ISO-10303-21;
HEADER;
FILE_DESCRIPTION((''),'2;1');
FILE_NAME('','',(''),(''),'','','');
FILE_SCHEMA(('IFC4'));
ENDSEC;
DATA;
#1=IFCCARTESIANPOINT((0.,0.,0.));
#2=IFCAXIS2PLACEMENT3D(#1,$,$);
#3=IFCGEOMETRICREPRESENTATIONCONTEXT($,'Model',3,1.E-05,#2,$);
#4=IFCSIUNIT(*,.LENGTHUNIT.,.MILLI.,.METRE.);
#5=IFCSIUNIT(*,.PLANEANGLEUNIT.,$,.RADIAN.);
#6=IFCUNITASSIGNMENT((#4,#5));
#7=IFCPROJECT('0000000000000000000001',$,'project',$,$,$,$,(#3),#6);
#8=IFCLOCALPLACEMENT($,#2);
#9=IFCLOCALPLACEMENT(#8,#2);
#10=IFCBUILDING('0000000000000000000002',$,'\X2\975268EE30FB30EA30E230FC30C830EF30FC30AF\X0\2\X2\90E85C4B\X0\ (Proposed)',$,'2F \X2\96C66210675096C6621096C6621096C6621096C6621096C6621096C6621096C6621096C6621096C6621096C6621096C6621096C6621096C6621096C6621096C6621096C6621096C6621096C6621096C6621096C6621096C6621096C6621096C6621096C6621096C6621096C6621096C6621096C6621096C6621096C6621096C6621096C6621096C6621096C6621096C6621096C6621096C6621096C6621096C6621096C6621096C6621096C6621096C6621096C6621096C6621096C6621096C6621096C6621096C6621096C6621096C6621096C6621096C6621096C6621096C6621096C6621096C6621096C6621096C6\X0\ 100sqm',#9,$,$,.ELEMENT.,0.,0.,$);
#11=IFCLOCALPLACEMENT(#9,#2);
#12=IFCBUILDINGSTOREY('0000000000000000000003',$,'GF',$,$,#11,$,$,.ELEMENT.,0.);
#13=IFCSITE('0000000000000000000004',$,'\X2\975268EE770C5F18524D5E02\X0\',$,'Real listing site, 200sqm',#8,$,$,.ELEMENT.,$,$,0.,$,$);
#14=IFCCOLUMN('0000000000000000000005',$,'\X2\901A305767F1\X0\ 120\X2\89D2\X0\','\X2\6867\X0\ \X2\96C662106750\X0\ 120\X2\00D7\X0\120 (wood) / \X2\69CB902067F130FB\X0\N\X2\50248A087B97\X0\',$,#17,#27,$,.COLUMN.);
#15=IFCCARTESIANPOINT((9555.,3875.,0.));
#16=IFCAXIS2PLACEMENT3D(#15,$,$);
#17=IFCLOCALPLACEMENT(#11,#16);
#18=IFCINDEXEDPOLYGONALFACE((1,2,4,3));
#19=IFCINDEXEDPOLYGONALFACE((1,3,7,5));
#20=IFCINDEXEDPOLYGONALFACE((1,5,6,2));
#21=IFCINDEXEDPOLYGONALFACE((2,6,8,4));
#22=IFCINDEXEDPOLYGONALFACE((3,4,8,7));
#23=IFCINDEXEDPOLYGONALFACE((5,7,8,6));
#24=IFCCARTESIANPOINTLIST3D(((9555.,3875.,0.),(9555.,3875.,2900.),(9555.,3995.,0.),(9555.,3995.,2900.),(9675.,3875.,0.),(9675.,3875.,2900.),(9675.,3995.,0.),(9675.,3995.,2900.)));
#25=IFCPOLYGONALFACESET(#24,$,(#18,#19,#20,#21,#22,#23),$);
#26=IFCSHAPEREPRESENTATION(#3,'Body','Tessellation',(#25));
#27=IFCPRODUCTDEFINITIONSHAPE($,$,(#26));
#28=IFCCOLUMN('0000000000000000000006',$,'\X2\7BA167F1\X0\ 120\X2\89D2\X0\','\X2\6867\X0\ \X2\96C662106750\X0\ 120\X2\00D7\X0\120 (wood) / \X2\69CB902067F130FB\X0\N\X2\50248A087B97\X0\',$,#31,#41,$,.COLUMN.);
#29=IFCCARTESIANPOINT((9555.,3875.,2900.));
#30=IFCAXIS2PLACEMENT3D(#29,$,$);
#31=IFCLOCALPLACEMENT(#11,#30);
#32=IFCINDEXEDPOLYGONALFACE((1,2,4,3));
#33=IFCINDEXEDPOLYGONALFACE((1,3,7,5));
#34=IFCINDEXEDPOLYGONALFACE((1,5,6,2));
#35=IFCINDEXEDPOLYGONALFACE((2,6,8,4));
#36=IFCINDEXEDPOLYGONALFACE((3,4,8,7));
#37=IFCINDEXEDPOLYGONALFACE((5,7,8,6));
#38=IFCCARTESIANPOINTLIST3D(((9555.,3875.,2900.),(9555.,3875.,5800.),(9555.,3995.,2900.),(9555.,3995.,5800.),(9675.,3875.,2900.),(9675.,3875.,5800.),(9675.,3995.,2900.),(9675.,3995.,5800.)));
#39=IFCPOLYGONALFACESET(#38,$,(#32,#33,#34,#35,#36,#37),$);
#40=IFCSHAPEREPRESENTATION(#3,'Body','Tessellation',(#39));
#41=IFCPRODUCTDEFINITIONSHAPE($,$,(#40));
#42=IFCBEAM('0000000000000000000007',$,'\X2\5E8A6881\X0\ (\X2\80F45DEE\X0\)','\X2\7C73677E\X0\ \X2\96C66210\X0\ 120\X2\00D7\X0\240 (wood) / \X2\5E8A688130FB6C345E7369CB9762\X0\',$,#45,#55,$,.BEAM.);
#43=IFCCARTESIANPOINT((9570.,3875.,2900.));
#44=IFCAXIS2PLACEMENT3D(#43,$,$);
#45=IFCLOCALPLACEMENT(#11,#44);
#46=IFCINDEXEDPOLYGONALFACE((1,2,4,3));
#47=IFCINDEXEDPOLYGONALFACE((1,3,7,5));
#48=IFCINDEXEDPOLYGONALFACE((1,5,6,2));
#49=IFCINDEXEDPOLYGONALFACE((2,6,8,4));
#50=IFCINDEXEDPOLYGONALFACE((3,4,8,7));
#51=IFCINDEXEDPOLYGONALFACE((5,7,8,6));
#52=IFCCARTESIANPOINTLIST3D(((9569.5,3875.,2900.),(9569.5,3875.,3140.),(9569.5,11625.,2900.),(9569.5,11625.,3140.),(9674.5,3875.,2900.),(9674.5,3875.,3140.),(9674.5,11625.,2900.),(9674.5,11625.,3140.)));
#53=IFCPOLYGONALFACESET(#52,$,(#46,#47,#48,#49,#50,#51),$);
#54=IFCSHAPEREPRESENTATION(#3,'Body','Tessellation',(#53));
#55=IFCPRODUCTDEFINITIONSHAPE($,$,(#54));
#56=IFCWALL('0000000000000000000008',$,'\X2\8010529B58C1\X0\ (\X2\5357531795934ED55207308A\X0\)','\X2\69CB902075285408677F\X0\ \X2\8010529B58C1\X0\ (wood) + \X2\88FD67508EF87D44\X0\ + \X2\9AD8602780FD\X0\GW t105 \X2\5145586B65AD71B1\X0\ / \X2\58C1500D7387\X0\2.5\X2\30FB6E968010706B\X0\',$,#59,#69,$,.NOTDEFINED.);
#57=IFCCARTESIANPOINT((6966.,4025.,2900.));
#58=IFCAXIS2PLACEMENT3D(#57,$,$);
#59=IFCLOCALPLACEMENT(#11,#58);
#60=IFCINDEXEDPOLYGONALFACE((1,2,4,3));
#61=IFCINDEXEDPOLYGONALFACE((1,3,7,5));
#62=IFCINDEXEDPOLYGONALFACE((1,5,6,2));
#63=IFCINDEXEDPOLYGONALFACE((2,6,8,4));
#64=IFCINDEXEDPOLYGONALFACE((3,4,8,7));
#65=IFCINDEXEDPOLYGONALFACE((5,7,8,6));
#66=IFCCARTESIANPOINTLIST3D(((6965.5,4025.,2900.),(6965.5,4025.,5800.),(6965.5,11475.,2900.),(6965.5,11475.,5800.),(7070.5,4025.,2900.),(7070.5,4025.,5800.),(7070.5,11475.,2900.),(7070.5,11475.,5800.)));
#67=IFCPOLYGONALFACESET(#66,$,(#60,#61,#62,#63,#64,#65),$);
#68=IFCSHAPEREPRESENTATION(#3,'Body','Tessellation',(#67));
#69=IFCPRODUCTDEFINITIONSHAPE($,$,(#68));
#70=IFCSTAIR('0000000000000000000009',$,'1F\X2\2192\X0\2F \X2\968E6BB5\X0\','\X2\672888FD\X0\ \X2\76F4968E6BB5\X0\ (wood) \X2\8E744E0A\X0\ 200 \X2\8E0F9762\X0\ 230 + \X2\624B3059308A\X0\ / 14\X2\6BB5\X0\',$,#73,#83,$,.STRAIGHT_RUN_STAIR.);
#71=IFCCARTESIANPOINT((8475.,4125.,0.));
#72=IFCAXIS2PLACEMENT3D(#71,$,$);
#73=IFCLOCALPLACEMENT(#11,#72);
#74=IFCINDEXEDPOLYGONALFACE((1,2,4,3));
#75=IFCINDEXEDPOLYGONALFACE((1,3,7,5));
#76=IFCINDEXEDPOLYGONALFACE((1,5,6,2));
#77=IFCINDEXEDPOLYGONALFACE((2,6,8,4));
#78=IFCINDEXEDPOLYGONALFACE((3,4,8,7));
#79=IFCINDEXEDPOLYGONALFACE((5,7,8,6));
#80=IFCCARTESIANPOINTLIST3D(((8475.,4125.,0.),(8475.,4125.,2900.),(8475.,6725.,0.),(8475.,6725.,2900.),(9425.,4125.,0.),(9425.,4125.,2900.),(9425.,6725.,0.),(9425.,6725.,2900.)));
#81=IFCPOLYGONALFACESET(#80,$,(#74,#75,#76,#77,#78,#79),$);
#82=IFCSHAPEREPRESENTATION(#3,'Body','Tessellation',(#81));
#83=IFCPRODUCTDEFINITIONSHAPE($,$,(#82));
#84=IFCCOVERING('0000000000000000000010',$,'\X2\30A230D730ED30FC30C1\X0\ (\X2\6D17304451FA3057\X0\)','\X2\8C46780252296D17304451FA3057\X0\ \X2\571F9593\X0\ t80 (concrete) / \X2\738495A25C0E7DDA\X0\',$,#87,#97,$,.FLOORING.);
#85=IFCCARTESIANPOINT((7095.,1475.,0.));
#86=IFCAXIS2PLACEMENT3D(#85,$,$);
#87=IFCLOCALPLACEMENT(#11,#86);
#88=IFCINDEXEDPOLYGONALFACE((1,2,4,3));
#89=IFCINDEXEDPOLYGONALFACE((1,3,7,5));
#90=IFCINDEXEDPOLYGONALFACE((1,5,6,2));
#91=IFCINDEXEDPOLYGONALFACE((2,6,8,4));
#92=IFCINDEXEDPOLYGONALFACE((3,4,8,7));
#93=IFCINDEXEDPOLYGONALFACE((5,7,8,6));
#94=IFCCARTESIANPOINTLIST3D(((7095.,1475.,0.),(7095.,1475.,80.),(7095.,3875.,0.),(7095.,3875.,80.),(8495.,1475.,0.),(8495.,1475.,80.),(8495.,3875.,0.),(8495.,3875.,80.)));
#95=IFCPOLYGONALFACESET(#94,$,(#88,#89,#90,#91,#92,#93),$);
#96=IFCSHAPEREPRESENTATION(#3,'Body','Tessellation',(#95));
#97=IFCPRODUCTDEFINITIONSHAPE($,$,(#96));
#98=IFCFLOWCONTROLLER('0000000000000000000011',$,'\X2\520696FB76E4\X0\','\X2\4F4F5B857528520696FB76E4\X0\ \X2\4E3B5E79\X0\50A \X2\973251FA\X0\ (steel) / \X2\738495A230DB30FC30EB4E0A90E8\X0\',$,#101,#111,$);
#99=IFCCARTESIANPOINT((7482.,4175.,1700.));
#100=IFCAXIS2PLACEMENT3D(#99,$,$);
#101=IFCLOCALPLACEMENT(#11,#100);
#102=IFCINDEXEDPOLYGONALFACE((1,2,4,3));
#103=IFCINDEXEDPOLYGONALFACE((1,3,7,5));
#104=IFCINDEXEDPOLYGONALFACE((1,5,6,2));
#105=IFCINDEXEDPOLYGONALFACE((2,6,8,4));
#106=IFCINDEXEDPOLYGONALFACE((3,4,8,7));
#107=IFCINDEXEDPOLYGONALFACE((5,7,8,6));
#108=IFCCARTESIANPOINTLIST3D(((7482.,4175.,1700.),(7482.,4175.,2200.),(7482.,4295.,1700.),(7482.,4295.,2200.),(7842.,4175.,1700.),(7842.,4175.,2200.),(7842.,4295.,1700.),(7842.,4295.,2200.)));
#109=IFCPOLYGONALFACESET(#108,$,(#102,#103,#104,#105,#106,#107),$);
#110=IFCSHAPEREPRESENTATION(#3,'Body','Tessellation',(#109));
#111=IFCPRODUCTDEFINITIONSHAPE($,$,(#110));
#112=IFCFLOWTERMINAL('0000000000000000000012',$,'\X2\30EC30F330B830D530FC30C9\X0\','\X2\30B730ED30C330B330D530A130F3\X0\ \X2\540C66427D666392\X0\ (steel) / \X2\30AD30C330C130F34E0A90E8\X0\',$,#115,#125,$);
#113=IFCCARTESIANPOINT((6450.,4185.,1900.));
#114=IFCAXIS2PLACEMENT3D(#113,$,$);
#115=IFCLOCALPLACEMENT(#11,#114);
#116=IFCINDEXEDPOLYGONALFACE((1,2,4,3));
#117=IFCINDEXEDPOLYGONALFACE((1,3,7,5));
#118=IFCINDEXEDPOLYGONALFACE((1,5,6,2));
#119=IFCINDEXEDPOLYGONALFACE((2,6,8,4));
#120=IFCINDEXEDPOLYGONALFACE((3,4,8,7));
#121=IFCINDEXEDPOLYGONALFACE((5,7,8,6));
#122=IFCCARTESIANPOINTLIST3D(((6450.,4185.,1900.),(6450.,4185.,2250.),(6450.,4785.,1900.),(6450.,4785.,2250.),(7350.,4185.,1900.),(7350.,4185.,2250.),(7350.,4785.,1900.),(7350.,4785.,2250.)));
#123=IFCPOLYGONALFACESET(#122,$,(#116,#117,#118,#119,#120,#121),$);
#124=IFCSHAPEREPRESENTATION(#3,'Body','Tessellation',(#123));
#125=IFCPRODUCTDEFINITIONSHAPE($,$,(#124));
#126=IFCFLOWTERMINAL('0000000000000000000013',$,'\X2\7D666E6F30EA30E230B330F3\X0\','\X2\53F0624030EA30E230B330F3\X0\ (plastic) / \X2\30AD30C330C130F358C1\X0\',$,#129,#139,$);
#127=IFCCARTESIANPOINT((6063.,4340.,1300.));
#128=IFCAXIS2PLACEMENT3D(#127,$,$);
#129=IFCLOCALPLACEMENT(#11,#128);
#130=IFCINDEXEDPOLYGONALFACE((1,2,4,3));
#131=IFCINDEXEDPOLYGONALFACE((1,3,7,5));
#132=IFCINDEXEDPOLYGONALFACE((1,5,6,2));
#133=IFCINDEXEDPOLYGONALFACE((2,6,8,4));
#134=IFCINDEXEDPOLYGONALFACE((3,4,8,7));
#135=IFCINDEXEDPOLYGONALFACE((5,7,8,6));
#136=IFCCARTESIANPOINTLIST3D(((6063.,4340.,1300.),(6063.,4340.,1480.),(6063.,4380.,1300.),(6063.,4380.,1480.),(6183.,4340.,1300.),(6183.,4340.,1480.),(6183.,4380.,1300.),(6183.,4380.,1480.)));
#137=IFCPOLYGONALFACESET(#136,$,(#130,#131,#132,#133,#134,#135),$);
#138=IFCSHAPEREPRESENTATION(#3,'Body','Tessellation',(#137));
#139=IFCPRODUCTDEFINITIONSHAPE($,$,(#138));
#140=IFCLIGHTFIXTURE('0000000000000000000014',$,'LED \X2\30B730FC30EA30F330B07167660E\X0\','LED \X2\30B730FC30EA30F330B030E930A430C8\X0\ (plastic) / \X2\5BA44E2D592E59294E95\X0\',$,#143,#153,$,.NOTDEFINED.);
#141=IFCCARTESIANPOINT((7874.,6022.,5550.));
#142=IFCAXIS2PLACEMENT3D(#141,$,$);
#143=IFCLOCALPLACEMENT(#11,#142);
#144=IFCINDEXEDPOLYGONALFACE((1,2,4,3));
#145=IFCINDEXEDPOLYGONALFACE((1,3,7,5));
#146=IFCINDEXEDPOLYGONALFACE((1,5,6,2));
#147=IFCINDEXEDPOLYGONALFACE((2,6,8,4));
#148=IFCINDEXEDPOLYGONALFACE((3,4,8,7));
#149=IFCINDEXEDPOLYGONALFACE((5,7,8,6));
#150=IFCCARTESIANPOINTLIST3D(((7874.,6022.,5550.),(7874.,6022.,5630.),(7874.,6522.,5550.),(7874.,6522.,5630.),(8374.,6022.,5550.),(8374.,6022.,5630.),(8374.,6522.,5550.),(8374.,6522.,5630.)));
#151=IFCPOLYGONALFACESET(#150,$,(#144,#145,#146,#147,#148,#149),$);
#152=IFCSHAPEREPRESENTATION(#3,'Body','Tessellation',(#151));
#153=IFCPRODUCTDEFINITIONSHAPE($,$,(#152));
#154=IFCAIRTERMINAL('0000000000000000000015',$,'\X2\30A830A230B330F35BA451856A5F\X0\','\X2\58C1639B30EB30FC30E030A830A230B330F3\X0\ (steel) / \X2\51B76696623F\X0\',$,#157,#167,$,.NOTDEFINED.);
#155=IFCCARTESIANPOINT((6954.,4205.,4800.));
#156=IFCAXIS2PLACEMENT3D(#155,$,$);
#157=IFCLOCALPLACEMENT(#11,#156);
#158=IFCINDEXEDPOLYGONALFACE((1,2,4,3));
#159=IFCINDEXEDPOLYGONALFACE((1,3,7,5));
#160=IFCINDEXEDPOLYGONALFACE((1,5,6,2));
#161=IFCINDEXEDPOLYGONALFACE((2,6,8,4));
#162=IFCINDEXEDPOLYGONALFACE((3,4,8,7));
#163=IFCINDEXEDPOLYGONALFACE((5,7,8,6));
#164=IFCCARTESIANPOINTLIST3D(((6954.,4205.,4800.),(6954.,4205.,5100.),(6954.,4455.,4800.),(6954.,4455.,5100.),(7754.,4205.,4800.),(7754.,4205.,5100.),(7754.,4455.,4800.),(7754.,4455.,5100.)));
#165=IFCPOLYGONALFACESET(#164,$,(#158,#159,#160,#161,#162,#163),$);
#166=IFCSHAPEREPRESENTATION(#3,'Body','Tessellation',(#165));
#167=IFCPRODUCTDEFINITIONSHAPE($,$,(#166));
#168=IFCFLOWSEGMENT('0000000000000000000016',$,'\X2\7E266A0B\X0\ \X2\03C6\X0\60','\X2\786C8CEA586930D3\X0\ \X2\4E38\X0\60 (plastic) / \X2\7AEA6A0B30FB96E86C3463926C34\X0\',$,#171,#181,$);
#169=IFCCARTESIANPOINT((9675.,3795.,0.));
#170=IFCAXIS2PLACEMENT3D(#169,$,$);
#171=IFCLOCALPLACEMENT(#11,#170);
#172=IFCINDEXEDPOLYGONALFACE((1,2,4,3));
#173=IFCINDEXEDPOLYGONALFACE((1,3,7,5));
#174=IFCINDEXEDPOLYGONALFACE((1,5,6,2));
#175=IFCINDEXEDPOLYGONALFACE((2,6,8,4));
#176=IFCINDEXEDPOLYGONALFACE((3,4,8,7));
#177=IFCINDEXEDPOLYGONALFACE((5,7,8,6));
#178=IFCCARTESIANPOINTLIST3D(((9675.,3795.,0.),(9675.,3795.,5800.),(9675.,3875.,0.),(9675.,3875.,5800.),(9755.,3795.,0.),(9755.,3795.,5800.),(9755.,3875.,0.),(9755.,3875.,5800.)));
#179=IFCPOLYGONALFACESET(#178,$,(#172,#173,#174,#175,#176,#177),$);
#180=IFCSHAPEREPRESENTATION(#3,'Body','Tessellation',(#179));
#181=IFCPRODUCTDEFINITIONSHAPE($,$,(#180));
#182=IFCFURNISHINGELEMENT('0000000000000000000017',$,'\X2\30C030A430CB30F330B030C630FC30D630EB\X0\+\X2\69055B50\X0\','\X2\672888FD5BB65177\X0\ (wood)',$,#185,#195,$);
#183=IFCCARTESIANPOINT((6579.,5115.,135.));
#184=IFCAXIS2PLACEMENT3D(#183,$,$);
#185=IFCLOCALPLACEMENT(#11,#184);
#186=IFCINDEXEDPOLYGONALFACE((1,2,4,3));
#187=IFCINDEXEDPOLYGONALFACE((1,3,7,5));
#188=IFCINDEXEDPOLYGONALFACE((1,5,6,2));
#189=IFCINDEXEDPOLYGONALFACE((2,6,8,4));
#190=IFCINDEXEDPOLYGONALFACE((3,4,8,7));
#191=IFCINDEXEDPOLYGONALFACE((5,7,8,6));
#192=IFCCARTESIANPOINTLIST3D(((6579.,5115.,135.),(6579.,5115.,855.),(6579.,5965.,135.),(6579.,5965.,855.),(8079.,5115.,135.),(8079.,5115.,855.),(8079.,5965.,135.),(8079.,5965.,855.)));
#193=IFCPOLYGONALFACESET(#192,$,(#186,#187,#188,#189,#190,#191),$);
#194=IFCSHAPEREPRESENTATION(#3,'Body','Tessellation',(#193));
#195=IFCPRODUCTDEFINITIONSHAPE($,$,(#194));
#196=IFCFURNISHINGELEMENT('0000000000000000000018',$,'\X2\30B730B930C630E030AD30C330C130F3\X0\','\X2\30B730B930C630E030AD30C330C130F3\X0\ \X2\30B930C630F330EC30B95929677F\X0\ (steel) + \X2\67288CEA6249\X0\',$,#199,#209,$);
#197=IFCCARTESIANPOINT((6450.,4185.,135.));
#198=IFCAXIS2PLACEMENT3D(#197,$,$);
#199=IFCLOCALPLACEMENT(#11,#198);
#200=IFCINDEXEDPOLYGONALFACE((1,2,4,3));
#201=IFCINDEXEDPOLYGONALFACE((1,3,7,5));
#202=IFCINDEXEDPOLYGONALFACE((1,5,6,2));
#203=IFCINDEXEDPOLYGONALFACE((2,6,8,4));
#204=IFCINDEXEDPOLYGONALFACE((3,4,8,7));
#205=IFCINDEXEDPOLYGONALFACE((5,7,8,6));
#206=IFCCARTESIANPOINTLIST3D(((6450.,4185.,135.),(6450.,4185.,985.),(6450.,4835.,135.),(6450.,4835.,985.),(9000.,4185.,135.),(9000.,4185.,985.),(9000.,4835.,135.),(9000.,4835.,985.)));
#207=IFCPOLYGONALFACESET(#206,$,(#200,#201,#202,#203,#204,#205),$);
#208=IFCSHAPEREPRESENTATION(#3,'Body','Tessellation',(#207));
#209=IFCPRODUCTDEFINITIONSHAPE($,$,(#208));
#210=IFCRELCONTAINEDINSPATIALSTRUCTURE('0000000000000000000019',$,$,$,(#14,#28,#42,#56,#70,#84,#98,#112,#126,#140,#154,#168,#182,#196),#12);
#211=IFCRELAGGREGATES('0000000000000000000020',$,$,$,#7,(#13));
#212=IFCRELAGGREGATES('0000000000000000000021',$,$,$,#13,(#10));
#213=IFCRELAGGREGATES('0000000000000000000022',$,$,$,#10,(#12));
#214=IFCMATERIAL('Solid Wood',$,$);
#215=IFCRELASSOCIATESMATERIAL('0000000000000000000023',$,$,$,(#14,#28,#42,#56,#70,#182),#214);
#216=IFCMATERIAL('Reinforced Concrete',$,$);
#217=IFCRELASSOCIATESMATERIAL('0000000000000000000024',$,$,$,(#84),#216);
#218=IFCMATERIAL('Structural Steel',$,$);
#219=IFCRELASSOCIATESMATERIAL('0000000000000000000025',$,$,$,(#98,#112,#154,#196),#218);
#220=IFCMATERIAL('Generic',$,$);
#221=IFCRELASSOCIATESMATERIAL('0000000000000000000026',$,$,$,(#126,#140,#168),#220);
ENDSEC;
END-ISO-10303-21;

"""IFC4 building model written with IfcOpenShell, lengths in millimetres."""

from ifc_helpers import new_model, si_unit, frame, frame_2d, origin, place, context, project, spatial, rectangle, extrude, material, element, save


model = new_model("IFC4")

# Units and contexts
model_context = context("Model", 3, precision=1e-05, world=origin())
ifc_project = project(units=[si_unit("LENGTHUNIT", "METRE", prefix="MILLI"), si_unit("PLANEANGLEUNIT", "RADIAN")], contexts=[model_context])

# Site, building, storey
site_placement = place(None, origin())
site = spatial("IfcSite", under=ifc_project, at=site_placement, Name="青森県弘前市", ObjectType="Real listing site, 200sqm", CompositionType="ELEMENT", RefElevation=0.0)
building_placement = place(site_placement, origin())
building = spatial("IfcBuilding", under=site, at=building_placement, Name="青森・リモートワーク2部屋 (Proposed)", ObjectType="2F 集成材集成集成集成集成集成集成集成集成集成集成集成集成集成集成集成集成集成集成集成集成集成集成集成集成集成集成集成集成集成集成集成集成集成集成集成集成集成集成集成集成集成集成集成集成集成集成集成集成集成集成集成集成集成集成集成集成集成集成集 100sqm", CompositionType="ELEMENT", ElevationOfRefHeight=0.0, ElevationOfTerrain=0.0)
storey_placement = place(building_placement, origin())
storey = spatial("IfcBuildingStorey", under=building, at=storey_placement, Name="GF", CompositionType="ELEMENT", Elevation=0.0)

# Columns
ifc_material_1 = material(Name="Solid Wood")
column_1_placement = place(storey_placement, frame((9555.0, 3875.0, 0.0)))
element("IfcColumn", 1, at=column_1_placement, inside=storey, material=ifc_material_1, Name="通し柱 120角", Description="桧 集成材 120×120 (wood) / 構造柱・N値計算", PredefinedType="COLUMN", context=model_context, shape_type="SweptSolid", body=[
    extrude(rectangle(XDim=120.0, YDim=120.0, at=frame_2d((60.0, 60.0))), frame((9555.0, 3875.0, 0.0)), (0.0, 0.0, 1.0), 2900.0),
])
column_2_placement = place(storey_placement, frame((9555.0, 3875.0, 2900.0)))
element("IfcColumn", 2, at=column_2_placement, inside=storey, material=ifc_material_1, Name="管柱 120角", Description="桧 集成材 120×120 (wood) / 構造柱・N値計算", PredefinedType="COLUMN", context=model_context, shape_type="SweptSolid", body=[
    extrude(rectangle(XDim=120.0, YDim=120.0, at=frame_2d((60.0, 60.0))), frame((9555.0, 3875.0, 2900.0)), (0.0, 0.0, 1.0), 2900.0),
])

# Beam
beam_1_placement = place(storey_placement, frame((9570.0, 3875.0, 2900.0)))
element("IfcBeam", 3, at=beam_1_placement, inside=storey, material=ifc_material_1, Name="床梁 (胴差)", Description="米松 集成 120×240 (wood) / 床梁・水平構面", PredefinedType="BEAM", context=model_context, shape_type="SweptSolid", body=[
    extrude(rectangle(XDim=105.0, YDim=7750.0, at=frame_2d((52.0, 3875.0))), frame((9570.0, 3875.0, 2900.0)), (0.0, 0.0, 1.0), 240.0),
])

# Wall
wall_1_placement = place(storey_placement, frame((6966.0, 4025.0, 2900.0)))
element("IfcWall", 4, at=wall_1_placement, inside=storey, material=ifc_material_1, Name="耐力壁 (南北間仕切り)", Description="構造用合板 耐力壁 (wood) + 製材軸組 + 高性能GW t105 充填断熱 / 壁倍率2.5・準耐火", PredefinedType="NOTDEFINED", context=model_context, shape_type="SweptSolid", body=[
    extrude(rectangle(XDim=105.0, YDim=7450.0, at=frame_2d((52.0, 3725.0))), frame((6966.0, 4025.0, 2900.0)), (0.0, 0.0, 1.0), 2900.0),
])

# Stair
stair_placement = place(storey_placement, frame((8475.0, 4125.0, 0.0)))
element("IfcStair", 5, at=stair_placement, inside=storey, material=ifc_material_1, Name="1F→2F 階段", Description="木製 直階段 (wood) 蹴上 200 踏面 230 + 手すり / 14段", PredefinedType="STRAIGHT_RUN_STAIR", context=model_context, shape_type="SweptSolid", body=[
    extrude(rectangle(XDim=950.0, YDim=2600.0, at=frame_2d((475.0, 1300.0))), frame((8475.0, 4125.0, 0.0)), (0.0, 0.0, 1.0), 2900.0),
])

# Covering
ifc_material_2 = material(Name="Reinforced Concrete")
covering_placement = place(storey_placement, frame((7095.0, 1475.0, 0.0)))
element("IfcCovering", 6, at=covering_placement, inside=storey, material=ifc_material_2, Name="アプローチ (洗い出し)", Description="豆砂利洗い出し 土間 t80 (concrete) / 玄関導線", PredefinedType="FLOORING", context=model_context, shape_type="SweptSolid", body=[
    extrude(rectangle(XDim=1400.0, YDim=2400.0, at=frame_2d((700.0, 1200.0))), frame((7095.0, 1475.0, 0.0)), (0.0, 0.0, 1.0), 80.0),
])

# Flow controller
ifc_material_3 = material(Name="Structural Steel")
flow_controller_placement = place(storey_placement, frame((7482.0, 4175.0, 1700.0)))
element("IfcFlowController", 7, at=flow_controller_placement, inside=storey, material=ifc_material_3, Name="分電盤", Description="住宅用分電盤 主幹50A 露出 (steel) / 玄関ホール上部", context=model_context, shape_type="SweptSolid", body=[
    extrude(rectangle(XDim=360.0, YDim=120.0, at=frame_2d((180.0, 60.0))), frame((7482.0, 4175.0, 1700.0)), (0.0, 0.0, 1.0), 500.0),
])

# Flow terminals
flow_terminal_1_placement = place(storey_placement, frame((6450.0, 4185.0, 1900.0)))
element("IfcFlowTerminal", 8, at=flow_terminal_1_placement, inside=storey, material=ifc_material_3, Name="レンジフード", Description="シロッコファン 同時給排 (steel) / キッチン上部", context=model_context, shape_type="SweptSolid", body=[
    extrude(rectangle(XDim=900.0, YDim=600.0, at=frame_2d((450.0, 300.0))), frame((6450.0, 4185.0, 1900.0)), (0.0, 0.0, 1.0), 350.0),
])
ifc_material_4 = material(Name="Generic")
flow_terminal_2_placement = place(storey_placement, frame((6063.0, 4340.0, 1300.0)))
element("IfcFlowTerminal", 9, at=flow_terminal_2_placement, inside=storey, material=ifc_material_4, Name="給湯リモコン", Description="台所リモコン (plastic) / キッチン壁", context=model_context, shape_type="SweptSolid", body=[
    extrude(rectangle(XDim=120.0, YDim=40.0, at=frame_2d((60.0, 20.0))), frame((6063.0, 4340.0, 1300.0)), (0.0, 0.0, 1.0), 180.0),
])

# Light fixture
light_fixture_placement = place(storey_placement, frame((7874.0, 6022.0, 5550.0)))
element("IfcLightFixture", 10, at=light_fixture_placement, inside=storey, material=ifc_material_4, Name="LED シーリング照明", Description="LED シーリングライト (plastic) / 室中央天井", PredefinedType="NOTDEFINED", context=model_context, shape_type="SweptSolid", body=[
    extrude(rectangle(XDim=500.0, YDim=500.0, at=frame_2d((250.0, 250.0))), frame((7874.0, 6022.0, 5550.0)), (0.0, 0.0, 1.0), 80.0),
])

# Air terminal
air_terminal_placement = place(storey_placement, frame((6954.0, 4205.0, 4800.0)))
element("IfcAirTerminal", 11, at=air_terminal_placement, inside=storey, material=ifc_material_3, Name="エアコン室内機", Description="壁掛ルームエアコン (steel) / 冷暖房", PredefinedType="NOTDEFINED", context=model_context, shape_type="SweptSolid", body=[
    extrude(rectangle(XDim=800.0, YDim=250.0, at=frame_2d((400.0, 125.0))), frame((6954.0, 4205.0, 4800.0)), (0.0, 0.0, 1.0), 300.0),
])

# Flow segment
flow_segment_placement = place(storey_placement, frame((9675.0, 3795.0, 0.0)))
element("IfcFlowSegment", 12, at=flow_segment_placement, inside=storey, material=ifc_material_4, Name="縦樋 φ60", Description="硬質塩ビ 丸60 (plastic) / 竪樋・雨水排水", context=model_context, shape_type="SweptSolid", body=[
    extrude(rectangle(XDim=80.0, YDim=80.0, at=frame_2d((40.0, 40.0))), frame((9675.0, 3795.0, 0.0)), (0.0, 0.0, 1.0), 5800.0),
])

# Furnishing elements
furnishing_1_placement = place(storey_placement, frame((6579.0, 5115.0, 135.0)))
element("IfcFurnishingElement", 13, at=furnishing_1_placement, inside=storey, material=ifc_material_1, Name="ダイニングテーブル+椅子", Description="木製家具 (wood)", context=model_context, shape_type="SweptSolid", body=[
    extrude(rectangle(XDim=1500.0, YDim=850.0, at=frame_2d((750.0, 425.0))), frame((6579.0, 5115.0, 135.0)), (0.0, 0.0, 1.0), 720.0),
])
furnishing_2_placement = place(storey_placement, frame((6450.0, 4185.0, 135.0)))
element("IfcFurnishingElement", 14, at=furnishing_2_placement, inside=storey, material=ifc_material_3, Name="システムキッチン", Description="システムキッチン ステンレス天板 (steel) + 木質扉", context=model_context, shape_type="SweptSolid", body=[
    extrude(rectangle(XDim=2550.0, YDim=650.0, at=frame_2d((1275.0, 325.0))), frame((6450.0, 4185.0, 135.0)), (0.0, 0.0, 1.0), 850.0),
])

save(model, "model.ifc")
